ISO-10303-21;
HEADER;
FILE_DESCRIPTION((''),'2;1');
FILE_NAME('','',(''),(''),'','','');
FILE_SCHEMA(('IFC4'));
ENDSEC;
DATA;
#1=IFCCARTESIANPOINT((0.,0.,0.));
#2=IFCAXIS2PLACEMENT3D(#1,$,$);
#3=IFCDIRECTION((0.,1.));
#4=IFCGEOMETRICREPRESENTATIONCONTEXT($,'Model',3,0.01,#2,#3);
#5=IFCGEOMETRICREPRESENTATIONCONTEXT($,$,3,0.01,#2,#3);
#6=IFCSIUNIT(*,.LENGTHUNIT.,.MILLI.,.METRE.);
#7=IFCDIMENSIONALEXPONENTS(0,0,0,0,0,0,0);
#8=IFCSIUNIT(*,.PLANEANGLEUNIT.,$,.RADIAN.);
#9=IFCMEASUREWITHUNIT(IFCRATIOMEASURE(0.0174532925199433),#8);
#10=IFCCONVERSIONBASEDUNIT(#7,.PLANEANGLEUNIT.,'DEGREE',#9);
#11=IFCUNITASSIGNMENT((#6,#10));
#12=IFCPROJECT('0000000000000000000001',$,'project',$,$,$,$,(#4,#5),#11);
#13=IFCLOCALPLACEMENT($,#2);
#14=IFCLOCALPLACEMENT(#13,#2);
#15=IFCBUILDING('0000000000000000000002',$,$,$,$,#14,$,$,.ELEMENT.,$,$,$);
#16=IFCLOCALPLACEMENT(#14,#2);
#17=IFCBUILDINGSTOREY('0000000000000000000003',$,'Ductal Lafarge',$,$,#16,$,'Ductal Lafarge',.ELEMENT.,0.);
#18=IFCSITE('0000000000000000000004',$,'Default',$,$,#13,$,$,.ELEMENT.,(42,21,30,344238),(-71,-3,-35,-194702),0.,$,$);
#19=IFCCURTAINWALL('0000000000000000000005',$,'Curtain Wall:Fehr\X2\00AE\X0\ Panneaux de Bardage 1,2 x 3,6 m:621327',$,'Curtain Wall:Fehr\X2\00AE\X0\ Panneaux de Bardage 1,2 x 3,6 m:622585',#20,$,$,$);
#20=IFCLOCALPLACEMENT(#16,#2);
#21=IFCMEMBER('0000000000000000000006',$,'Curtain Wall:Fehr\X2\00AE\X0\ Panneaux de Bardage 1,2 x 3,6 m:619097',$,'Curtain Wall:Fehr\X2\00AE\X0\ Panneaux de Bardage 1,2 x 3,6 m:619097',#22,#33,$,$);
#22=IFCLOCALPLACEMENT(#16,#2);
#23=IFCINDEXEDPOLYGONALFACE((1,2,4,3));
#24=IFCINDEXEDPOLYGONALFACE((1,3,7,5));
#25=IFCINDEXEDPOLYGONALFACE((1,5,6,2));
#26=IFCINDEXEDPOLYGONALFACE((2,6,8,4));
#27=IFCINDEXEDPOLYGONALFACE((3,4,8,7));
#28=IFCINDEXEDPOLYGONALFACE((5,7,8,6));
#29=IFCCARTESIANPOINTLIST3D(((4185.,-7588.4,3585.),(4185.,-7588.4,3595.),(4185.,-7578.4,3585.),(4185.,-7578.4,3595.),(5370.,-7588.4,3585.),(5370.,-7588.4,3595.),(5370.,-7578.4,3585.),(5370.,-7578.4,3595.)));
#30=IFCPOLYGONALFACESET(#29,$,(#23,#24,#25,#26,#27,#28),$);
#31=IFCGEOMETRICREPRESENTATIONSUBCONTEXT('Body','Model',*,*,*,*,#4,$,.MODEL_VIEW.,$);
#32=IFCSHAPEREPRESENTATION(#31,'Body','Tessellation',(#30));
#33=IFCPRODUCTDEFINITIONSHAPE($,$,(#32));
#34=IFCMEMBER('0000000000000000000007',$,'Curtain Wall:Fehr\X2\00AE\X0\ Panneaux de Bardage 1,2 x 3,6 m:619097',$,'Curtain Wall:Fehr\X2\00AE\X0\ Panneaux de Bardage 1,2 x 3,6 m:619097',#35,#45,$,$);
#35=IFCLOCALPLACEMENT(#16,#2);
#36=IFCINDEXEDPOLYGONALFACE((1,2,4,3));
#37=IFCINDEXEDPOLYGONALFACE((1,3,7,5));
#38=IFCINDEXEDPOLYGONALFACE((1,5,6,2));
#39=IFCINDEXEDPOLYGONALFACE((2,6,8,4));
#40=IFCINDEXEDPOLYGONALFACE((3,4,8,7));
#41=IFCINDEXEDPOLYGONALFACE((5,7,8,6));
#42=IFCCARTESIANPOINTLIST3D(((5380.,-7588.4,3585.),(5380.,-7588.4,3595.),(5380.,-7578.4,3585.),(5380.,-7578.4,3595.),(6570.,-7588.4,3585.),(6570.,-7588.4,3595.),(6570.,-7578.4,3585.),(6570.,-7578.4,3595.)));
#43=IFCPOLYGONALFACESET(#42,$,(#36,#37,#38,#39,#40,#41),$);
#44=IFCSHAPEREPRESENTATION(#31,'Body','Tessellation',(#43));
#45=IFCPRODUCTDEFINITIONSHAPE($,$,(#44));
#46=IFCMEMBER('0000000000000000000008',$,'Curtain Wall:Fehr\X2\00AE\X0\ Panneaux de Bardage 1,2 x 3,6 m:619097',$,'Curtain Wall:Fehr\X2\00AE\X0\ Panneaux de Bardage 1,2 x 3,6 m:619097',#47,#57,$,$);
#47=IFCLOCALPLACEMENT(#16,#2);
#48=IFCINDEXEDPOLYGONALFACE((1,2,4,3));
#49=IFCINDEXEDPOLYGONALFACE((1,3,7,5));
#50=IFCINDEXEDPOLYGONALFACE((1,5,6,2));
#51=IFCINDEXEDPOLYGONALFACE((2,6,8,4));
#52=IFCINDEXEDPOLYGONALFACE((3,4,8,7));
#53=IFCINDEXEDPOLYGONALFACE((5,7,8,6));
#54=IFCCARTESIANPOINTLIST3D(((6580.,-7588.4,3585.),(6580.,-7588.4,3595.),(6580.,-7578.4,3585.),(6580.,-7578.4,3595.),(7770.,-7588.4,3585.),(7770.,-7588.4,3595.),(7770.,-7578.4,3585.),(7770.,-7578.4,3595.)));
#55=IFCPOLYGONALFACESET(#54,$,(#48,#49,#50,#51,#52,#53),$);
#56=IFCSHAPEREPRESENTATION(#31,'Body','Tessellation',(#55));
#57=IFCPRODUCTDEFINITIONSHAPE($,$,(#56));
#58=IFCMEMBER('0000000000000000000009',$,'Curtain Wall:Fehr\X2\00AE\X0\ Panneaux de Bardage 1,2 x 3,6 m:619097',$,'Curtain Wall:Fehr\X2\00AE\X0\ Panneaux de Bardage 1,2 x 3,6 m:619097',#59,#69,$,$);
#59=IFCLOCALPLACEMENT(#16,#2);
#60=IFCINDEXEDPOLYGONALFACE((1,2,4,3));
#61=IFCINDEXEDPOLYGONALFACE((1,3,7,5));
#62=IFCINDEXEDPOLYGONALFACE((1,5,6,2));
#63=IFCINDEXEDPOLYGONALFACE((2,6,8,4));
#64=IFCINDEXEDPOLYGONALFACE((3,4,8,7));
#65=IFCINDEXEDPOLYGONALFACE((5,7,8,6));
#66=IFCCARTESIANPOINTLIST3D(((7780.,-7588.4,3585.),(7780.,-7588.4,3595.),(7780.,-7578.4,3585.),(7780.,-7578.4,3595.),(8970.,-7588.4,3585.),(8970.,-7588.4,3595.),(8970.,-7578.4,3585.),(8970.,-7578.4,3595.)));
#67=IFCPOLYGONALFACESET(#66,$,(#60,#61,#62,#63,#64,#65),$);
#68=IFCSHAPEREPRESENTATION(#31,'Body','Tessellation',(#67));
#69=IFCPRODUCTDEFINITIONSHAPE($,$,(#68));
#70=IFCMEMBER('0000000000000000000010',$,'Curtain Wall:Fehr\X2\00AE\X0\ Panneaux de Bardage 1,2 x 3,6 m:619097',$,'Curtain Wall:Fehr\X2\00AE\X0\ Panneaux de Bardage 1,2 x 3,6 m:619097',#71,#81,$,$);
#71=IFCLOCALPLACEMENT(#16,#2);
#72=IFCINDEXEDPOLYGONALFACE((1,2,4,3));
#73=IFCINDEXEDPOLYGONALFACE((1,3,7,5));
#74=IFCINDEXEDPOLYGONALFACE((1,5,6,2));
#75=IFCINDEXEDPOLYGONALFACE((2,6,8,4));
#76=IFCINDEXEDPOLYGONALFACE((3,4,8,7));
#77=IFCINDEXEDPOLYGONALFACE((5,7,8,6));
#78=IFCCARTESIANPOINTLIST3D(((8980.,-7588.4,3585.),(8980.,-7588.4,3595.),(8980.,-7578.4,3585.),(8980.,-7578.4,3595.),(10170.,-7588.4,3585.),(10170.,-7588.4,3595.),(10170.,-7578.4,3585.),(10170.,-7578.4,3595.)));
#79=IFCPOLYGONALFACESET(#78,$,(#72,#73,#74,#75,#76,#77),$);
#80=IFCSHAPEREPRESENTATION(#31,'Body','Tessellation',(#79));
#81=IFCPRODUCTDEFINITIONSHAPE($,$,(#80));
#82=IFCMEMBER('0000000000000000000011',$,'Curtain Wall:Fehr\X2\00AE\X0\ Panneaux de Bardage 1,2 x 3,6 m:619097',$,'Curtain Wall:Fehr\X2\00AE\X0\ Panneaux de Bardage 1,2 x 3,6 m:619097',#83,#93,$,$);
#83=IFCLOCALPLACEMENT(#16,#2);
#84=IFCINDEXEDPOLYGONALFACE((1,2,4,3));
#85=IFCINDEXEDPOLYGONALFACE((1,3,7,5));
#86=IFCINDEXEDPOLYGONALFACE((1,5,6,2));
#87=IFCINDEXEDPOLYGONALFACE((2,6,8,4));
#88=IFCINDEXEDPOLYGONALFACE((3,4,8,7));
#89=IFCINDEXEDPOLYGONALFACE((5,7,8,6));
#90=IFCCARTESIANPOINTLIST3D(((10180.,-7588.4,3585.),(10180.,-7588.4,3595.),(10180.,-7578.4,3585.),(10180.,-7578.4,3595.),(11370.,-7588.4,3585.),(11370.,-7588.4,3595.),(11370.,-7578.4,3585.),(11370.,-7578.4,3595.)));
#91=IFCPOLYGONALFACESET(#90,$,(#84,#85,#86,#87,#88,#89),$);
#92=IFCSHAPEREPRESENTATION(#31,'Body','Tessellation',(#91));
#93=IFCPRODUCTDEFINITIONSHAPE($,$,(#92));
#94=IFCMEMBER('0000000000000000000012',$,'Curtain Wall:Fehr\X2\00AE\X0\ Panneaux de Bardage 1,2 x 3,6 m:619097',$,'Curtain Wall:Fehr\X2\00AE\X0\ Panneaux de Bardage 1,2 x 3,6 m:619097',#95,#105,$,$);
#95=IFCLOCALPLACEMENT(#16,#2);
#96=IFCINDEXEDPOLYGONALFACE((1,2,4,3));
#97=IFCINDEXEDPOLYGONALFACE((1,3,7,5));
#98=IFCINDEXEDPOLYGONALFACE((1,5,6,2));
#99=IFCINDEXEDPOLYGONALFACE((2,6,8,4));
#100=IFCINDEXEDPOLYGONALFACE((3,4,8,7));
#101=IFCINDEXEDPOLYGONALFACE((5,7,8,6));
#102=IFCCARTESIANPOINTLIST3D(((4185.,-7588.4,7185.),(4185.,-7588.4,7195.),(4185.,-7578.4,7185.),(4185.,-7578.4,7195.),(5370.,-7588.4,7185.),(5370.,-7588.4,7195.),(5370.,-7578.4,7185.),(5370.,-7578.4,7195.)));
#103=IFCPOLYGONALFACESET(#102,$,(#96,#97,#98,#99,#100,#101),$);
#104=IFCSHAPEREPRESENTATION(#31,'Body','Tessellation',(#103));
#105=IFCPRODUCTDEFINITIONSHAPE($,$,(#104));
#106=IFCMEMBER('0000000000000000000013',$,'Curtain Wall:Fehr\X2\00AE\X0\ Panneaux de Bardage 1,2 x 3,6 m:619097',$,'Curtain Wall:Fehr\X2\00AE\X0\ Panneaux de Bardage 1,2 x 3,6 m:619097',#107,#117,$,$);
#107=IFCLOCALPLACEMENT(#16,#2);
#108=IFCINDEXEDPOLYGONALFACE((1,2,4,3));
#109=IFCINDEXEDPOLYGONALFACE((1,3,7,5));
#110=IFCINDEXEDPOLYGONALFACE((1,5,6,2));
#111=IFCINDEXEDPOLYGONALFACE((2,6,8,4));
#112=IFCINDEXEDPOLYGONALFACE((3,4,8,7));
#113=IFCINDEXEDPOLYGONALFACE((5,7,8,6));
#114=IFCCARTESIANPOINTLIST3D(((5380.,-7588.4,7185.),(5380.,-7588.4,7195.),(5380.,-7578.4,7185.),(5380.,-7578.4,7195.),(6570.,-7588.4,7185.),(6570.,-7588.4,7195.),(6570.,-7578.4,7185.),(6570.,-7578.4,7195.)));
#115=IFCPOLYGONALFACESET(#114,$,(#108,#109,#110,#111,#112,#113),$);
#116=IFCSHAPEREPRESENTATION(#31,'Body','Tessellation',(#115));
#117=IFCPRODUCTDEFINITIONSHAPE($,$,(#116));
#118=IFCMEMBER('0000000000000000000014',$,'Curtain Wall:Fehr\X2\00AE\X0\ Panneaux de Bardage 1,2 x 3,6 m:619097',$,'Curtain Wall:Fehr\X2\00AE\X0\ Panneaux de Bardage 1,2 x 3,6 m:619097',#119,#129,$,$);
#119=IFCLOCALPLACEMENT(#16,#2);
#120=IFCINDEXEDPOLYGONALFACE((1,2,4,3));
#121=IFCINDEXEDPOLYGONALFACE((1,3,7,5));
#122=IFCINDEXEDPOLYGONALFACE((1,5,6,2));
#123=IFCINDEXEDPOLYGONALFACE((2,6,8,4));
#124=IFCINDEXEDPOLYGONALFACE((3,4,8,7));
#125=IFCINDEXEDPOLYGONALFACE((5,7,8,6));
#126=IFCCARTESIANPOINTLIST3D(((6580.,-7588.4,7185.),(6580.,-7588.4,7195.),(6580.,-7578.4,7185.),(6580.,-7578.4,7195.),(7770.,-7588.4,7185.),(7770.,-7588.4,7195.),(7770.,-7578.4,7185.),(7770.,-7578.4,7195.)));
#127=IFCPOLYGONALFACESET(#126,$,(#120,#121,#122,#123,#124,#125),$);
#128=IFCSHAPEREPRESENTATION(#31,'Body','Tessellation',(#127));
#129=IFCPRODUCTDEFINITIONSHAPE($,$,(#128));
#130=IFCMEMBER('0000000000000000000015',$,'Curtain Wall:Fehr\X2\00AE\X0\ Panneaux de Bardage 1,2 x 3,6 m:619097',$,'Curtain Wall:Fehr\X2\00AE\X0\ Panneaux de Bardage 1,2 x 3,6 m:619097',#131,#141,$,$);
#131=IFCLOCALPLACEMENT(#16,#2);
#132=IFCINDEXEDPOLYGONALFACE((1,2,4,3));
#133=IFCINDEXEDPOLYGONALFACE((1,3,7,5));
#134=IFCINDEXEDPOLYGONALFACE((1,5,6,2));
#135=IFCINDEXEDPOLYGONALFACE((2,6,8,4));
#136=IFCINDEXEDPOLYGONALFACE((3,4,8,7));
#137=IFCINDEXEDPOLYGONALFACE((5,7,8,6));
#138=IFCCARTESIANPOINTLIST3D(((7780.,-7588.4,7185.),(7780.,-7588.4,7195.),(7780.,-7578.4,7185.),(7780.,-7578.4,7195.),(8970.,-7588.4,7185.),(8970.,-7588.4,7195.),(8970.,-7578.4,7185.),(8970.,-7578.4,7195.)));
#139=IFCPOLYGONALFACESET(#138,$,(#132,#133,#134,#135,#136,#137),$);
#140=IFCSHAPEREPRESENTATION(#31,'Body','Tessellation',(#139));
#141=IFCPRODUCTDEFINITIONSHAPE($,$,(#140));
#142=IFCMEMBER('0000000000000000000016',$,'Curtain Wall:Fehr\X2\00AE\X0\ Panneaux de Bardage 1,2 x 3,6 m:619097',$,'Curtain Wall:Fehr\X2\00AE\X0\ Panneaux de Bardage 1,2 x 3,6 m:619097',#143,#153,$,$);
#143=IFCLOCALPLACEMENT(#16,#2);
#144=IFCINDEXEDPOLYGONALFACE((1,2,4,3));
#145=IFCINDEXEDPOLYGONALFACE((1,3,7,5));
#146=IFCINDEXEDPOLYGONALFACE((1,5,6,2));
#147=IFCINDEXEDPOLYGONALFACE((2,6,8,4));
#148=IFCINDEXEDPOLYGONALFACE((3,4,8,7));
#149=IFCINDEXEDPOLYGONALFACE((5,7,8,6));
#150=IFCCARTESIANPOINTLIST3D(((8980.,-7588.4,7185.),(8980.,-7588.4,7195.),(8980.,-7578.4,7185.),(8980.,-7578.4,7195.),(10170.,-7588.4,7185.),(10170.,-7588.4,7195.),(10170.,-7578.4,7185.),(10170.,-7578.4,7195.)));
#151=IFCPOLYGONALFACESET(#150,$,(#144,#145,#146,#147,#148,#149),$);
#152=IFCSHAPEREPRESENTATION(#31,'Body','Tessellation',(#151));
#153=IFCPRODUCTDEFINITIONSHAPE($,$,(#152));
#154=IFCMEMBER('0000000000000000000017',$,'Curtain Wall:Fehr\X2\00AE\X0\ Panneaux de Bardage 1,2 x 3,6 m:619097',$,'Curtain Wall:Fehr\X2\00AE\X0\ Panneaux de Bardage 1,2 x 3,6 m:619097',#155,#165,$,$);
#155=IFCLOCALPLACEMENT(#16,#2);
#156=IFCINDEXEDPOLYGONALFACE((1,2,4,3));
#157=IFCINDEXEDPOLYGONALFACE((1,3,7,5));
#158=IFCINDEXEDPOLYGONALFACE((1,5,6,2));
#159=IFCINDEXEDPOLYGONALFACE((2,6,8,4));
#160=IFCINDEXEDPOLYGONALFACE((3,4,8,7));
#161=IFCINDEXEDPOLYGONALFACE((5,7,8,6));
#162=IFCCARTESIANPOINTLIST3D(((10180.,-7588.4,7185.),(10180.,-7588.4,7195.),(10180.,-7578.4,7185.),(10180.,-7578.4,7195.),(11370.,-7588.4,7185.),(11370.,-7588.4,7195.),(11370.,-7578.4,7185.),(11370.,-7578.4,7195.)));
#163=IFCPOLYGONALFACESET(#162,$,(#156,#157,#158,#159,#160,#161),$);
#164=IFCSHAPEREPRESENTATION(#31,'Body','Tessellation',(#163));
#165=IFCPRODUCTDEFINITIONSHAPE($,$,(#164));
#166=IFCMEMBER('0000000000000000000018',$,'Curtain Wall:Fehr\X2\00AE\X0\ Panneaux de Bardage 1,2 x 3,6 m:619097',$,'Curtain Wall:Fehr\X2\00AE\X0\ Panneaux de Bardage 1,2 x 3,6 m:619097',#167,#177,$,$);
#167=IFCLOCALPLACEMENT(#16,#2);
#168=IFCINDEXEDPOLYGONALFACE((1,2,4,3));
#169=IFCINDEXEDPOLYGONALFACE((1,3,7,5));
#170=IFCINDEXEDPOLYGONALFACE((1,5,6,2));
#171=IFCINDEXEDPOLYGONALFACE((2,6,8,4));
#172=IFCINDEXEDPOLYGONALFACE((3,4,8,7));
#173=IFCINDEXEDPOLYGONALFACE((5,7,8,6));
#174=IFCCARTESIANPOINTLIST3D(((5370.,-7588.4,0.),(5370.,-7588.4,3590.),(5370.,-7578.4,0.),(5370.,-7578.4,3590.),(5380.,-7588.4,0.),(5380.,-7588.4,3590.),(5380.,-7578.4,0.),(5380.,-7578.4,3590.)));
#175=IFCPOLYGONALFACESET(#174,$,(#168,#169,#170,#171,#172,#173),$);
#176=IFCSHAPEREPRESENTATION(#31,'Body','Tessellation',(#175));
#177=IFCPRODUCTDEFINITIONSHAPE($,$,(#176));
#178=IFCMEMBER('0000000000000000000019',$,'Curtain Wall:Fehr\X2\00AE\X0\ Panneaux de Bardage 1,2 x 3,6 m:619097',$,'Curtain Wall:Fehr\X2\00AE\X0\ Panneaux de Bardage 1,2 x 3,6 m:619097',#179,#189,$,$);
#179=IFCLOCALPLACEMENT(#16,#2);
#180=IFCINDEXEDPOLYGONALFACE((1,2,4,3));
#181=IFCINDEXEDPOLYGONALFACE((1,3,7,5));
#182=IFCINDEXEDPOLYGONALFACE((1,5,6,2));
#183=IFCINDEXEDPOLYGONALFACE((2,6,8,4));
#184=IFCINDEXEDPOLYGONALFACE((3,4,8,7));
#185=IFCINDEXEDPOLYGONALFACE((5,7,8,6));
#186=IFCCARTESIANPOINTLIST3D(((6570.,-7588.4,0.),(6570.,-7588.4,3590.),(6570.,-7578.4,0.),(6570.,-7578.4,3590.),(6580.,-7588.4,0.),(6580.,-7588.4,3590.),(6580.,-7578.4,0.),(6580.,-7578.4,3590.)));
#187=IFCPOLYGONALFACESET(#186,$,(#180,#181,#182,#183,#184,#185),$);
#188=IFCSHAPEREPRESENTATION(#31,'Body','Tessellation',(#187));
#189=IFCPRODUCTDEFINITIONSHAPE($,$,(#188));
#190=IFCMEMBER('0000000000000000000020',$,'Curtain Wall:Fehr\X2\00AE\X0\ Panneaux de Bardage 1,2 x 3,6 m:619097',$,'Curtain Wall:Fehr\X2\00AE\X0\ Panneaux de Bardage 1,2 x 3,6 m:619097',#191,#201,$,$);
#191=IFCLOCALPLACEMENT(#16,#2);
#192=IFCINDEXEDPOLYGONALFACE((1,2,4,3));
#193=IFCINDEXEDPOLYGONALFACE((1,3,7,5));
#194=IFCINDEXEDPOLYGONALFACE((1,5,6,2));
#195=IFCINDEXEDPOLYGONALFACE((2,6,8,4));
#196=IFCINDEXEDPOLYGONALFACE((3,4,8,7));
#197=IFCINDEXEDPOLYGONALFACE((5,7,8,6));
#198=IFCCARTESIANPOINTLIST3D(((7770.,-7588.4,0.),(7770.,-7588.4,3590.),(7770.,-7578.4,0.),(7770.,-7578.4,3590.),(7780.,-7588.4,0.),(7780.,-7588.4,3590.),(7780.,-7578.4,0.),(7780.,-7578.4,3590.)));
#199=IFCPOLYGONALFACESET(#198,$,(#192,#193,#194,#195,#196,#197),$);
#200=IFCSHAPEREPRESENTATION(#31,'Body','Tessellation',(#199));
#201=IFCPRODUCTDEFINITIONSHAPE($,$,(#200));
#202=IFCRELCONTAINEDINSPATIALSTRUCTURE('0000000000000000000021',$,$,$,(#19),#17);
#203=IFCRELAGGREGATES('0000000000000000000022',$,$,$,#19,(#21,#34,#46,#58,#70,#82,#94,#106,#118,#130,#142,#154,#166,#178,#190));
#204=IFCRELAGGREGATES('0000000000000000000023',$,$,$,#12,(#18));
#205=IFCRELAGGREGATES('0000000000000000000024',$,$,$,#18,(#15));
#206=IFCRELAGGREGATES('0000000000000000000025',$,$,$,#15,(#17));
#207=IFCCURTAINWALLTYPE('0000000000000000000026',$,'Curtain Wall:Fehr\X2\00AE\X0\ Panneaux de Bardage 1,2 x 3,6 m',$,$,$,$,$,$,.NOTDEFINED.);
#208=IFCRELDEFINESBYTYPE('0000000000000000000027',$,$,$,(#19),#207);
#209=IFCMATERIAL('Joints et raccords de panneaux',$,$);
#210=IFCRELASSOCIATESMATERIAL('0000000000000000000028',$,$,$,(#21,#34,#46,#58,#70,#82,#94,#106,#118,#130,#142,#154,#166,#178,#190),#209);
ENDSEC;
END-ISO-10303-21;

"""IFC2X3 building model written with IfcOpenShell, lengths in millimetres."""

from ifc_helpers import new_model, entity, si_unit, converted_unit, direction, frame, frame_2d, origin, origin_2d_with_axis, place, context, subcontext, project, spatial, rectangle, extrude, material, type_object, element, aggregate, save


model = new_model("IFC2X3")

# Units and contexts
model_context = context("Model", 3, precision=0.01, world=origin(), true_north=direction((0.0, 1.0)))
context_of_model = context(None, 3, precision=0.01, world=origin(), true_north=direction((0.0, 1.0)))
body_context = subcontext(model_context, "Body", "Model", "MODEL_VIEW")
ifc_project = project(units=[si_unit("LENGTHUNIT", "METRE", prefix="MILLI"), converted_unit("PLANEANGLEUNIT", "DEGREE", entity("IfcRatioMeasure", 0.0174532925199433), si_unit("PLANEANGLEUNIT", "RADIAN"), dimensions=[0, 0, 0, 0, 0, 0, 0])], contexts=[model_context, context_of_model])

# Site, building, storey
site_placement = place(None, origin())
site = spatial("IfcSite", under=ifc_project, at=site_placement, Name="Default", CompositionType="ELEMENT", RefLatitude=(42, 21, 30, 344238), RefLongitude=(-71, -3, -35, -194702), RefElevation=0.0)
building_placement = place(site_placement, origin())
building = spatial("IfcBuilding", under=site, at=building_placement, CompositionType="ELEMENT")
storey_placement = place(building_placement, origin())
storey = spatial("IfcBuildingStorey", under=building, at=storey_placement, Name="Ductal Lafarge", LongName="Ductal Lafarge", CompositionType="ELEMENT", Elevation=0.0)

# Curtain wall, members
curtain_wall_type = type_object("IfcCurtainWallType", Name="Curtain Wall:Fehr® Panneaux de Bardage 1,2 x 3,6 m", PredefinedType="NOTDEFINED")
curtain_wall_placement = place(storey_placement, origin())
curtain_wall = element("IfcCurtainWall", 1, at=curtain_wall_placement, inside=storey, type_object=curtain_wall_type, Name="Curtain Wall:Fehr® Panneaux de Bardage 1,2 x 3,6 m:621327", ObjectType="Curtain Wall:Fehr® Panneaux de Bardage 1,2 x 3,6 m:622585")
ifc_material = material(Name="Joints et raccords de panneaux")
member_1_placement = place(curtain_wall_placement, frame((4185.0, -7588.4, 3585.0)))
member_1 = element("IfcMember", 2, at=member_1_placement, material=ifc_material, Name="Curtain Wall:Fehr® Panneaux de Bardage 1,2 x 3,6 m:619097", ObjectType="Curtain Wall:Fehr® Panneaux de Bardage 1,2 x 3,6 m:619097", context=body_context, shape_type="SweptSolid", body=[
    extrude(rectangle(XDim=1185.0, YDim=10.0, at=origin_2d_with_axis()), frame((592.5, 5.0, 0.0), z_axis=(0.0, 0.0, 1.0), x_axis=(-1.0, 0.0, 0.0)), (0.0, 0.0, 1.0), 10.0),
])
member_2_placement = place(curtain_wall_placement, frame((5380.0, -7588.4, 3585.0)))
member_2 = element("IfcMember", 3, at=member_2_placement, material=ifc_material, Name="Curtain Wall:Fehr® Panneaux de Bardage 1,2 x 3,6 m:619097", ObjectType="Curtain Wall:Fehr® Panneaux de Bardage 1,2 x 3,6 m:619097", context=body_context, shape_type="SweptSolid", body=[
    extrude(rectangle(XDim=1190.0, YDim=10.0, at=frame_2d((0.0, 0.0), x_axis=(1.0, 0.0))), frame((595.0, 5.0, 0.0), z_axis=(0.0, 0.0, 1.0), x_axis=(-1.0, 0.0, 0.0)), (0.0, 0.0, 1.0), 10.0),
])
member_3_placement = place(curtain_wall_placement, frame((6580.0, -7588.4, 3585.0)))
member_3 = element("IfcMember", 4, at=member_3_placement, material=ifc_material, Name="Curtain Wall:Fehr® Panneaux de Bardage 1,2 x 3,6 m:619097", ObjectType="Curtain Wall:Fehr® Panneaux de Bardage 1,2 x 3,6 m:619097", context=body_context, shape_type="SweptSolid", body=[
    extrude(rectangle(XDim=1190.0, YDim=10.0, at=frame_2d((0.0, 0.0), x_axis=(1.0, 0.0))), frame((595.0, 5.0, 0.0), z_axis=(0.0, 0.0, 1.0), x_axis=(-1.0, 0.0, 0.0)), (0.0, 0.0, 1.0), 10.0),
])
member_4_placement = place(curtain_wall_placement, frame((7780.0, -7588.4, 3585.0)))
member_4 = element("IfcMember", 5, at=member_4_placement, material=ifc_material, Name="Curtain Wall:Fehr® Panneaux de Bardage 1,2 x 3,6 m:619097", ObjectType="Curtain Wall:Fehr® Panneaux de Bardage 1,2 x 3,6 m:619097", context=body_context, shape_type="SweptSolid", body=[
    extrude(rectangle(XDim=1190.0, YDim=10.0, at=frame_2d((0.0, 0.0), x_axis=(1.0, 0.0))), frame((595.0, 5.0, 0.0), z_axis=(0.0, 0.0, 1.0), x_axis=(-1.0, 0.0, 0.0)), (0.0, 0.0, 1.0), 10.0),
])
member_5_placement = place(curtain_wall_placement, frame((8980.0, -7588.4, 3585.0)))
member_5 = element("IfcMember", 6, at=member_5_placement, material=ifc_material, Name="Curtain Wall:Fehr® Panneaux de Bardage 1,2 x 3,6 m:619097", ObjectType="Curtain Wall:Fehr® Panneaux de Bardage 1,2 x 3,6 m:619097", context=body_context, shape_type="SweptSolid", body=[
    extrude(rectangle(XDim=1190.0, YDim=10.0, at=origin_2d_with_axis()), frame((595.0, 5.0, 0.0), z_axis=(0.0, 0.0, 1.0), x_axis=(-1.0, 0.0, 0.0)), (0.0, 0.0, 1.0), 10.0),
])
member_6_placement = place(curtain_wall_placement, frame((10180.0, -7588.4, 3585.0)))
member_6 = element("IfcMember", 7, at=member_6_placement, material=ifc_material, Name="Curtain Wall:Fehr® Panneaux de Bardage 1,2 x 3,6 m:619097", ObjectType="Curtain Wall:Fehr® Panneaux de Bardage 1,2 x 3,6 m:619097", context=body_context, shape_type="SweptSolid", body=[
    extrude(rectangle(XDim=1190.0, YDim=10.0, at=frame_2d((0.0, 0.0), x_axis=(1.0, 0.0))), frame((595.0, 5.0, 0.0), z_axis=(0.0, 0.0, 1.0), x_axis=(-1.0, 0.0, 0.0)), (0.0, 0.0, 1.0), 10.0),
])
member_7_placement = place(curtain_wall_placement, frame((4185.0, -7588.4, 7185.0)))
member_7 = element("IfcMember", 8, at=member_7_placement, material=ifc_material, Name="Curtain Wall:Fehr® Panneaux de Bardage 1,2 x 3,6 m:619097", ObjectType="Curtain Wall:Fehr® Panneaux de Bardage 1,2 x 3,6 m:619097", context=body_context, shape_type="SweptSolid", body=[
    extrude(rectangle(XDim=1185.0, YDim=10.0, at=origin_2d_with_axis()), frame((592.5, 5.0, 0.0), z_axis=(0.0, 0.0, 1.0), x_axis=(-1.0, 0.0, 0.0)), (0.0, 0.0, 1.0), 10.0),
])
member_8_placement = place(curtain_wall_placement, frame((5380.0, -7588.4, 7185.0)))
member_8 = element("IfcMember", 9, at=member_8_placement, material=ifc_material, Name="Curtain Wall:Fehr® Panneaux de Bardage 1,2 x 3,6 m:619097", ObjectType="Curtain Wall:Fehr® Panneaux de Bardage 1,2 x 3,6 m:619097", context=body_context, shape_type="SweptSolid", body=[
    extrude(rectangle(XDim=1190.0, YDim=10.0, at=frame_2d((0.0, 0.0), x_axis=(1.0, 0.0))), frame((595.0, 5.0, 0.0), z_axis=(0.0, 0.0, 1.0), x_axis=(-1.0, 0.0, 0.0)), (0.0, 0.0, 1.0), 10.0),
])
member_9_placement = place(curtain_wall_placement, frame((6580.0, -7588.4, 7185.0)))
member_9 = element("IfcMember", 10, at=member_9_placement, material=ifc_material, Name="Curtain Wall:Fehr® Panneaux de Bardage 1,2 x 3,6 m:619097", ObjectType="Curtain Wall:Fehr® Panneaux de Bardage 1,2 x 3,6 m:619097", context=body_context, shape_type="SweptSolid", body=[
    extrude(rectangle(XDim=1190.0, YDim=10.0, at=frame_2d((0.0, 0.0), x_axis=(1.0, 0.0))), frame((595.0, 5.0, 0.0), z_axis=(0.0, 0.0, 1.0), x_axis=(-1.0, 0.0, 0.0)), (0.0, 0.0, 1.0), 10.0),
])
member_10_placement = place(curtain_wall_placement, frame((7780.0, -7588.4, 7185.0)))
member_10 = element("IfcMember", 11, at=member_10_placement, material=ifc_material, Name="Curtain Wall:Fehr® Panneaux de Bardage 1,2 x 3,6 m:619097", ObjectType="Curtain Wall:Fehr® Panneaux de Bardage 1,2 x 3,6 m:619097", context=body_context, shape_type="SweptSolid", body=[
    extrude(rectangle(XDim=1190.0, YDim=10.0, at=frame_2d((0.0, 0.0), x_axis=(1.0, 0.0))), frame((595.0, 5.0, 0.0), z_axis=(0.0, 0.0, 1.0), x_axis=(-1.0, 0.0, 0.0)), (0.0, 0.0, 1.0), 10.0),
])
member_11_placement = place(curtain_wall_placement, frame((8980.0, -7588.4, 7185.0)))
member_11 = element("IfcMember", 12, at=member_11_placement, material=ifc_material, Name="Curtain Wall:Fehr® Panneaux de Bardage 1,2 x 3,6 m:619097", ObjectType="Curtain Wall:Fehr® Panneaux de Bardage 1,2 x 3,6 m:619097", context=body_context, shape_type="SweptSolid", body=[
    extrude(rectangle(XDim=1190.0, YDim=10.0, at=origin_2d_with_axis()), frame((595.0, 5.0, 0.0), z_axis=(0.0, 0.0, 1.0), x_axis=(-1.0, 0.0, 0.0)), (0.0, 0.0, 1.0), 10.0),
])
member_12_placement = place(curtain_wall_placement, frame((10180.0, -7588.4, 7185.0)))
member_12 = element("IfcMember", 13, at=member_12_placement, material=ifc_material, Name="Curtain Wall:Fehr® Panneaux de Bardage 1,2 x 3,6 m:619097", ObjectType="Curtain Wall:Fehr® Panneaux de Bardage 1,2 x 3,6 m:619097", context=body_context, shape_type="SweptSolid", body=[
    extrude(rectangle(XDim=1190.0, YDim=10.0, at=frame_2d((0.0, 0.0), x_axis=(1.0, 0.0))), frame((595.0, 5.0, 0.0), z_axis=(0.0, 0.0, 1.0), x_axis=(-1.0, 0.0, 0.0)), (0.0, 0.0, 1.0), 10.0),
])
member_13_placement = place(curtain_wall_placement, frame((5370.0, -7588.4, 0.0)))
member_13 = element("IfcMember", 14, at=member_13_placement, material=ifc_material, Name="Curtain Wall:Fehr® Panneaux de Bardage 1,2 x 3,6 m:619097", ObjectType="Curtain Wall:Fehr® Panneaux de Bardage 1,2 x 3,6 m:619097", context=body_context, shape_type="SweptSolid", body=[
    extrude(rectangle(XDim=10.0, YDim=10.0, at=frame_2d((0.0, 0.0), x_axis=(1.0, 0.0))), frame((5.0, 5.0, 0.0), z_axis=(0.0, 0.0, 1.0), x_axis=(0.0, 1.0, 0.0)), (0.0, 0.0, 1.0), 3590.0),
])
member_14_placement = place(curtain_wall_placement, frame((6570.0, -7588.4, 0.0)))
member_14 = element("IfcMember", 15, at=member_14_placement, material=ifc_material, Name="Curtain Wall:Fehr® Panneaux de Bardage 1,2 x 3,6 m:619097", ObjectType="Curtain Wall:Fehr® Panneaux de Bardage 1,2 x 3,6 m:619097", context=body_context, shape_type="SweptSolid", body=[
    extrude(rectangle(XDim=10.0, YDim=10.0, at=frame_2d((0.0, 0.0), x_axis=(1.0, 0.0))), frame((5.0, 5.0, 0.0), z_axis=(0.0, 0.0, 1.0), x_axis=(0.0, 1.0, 0.0)), (0.0, 0.0, 1.0), 3590.0),
])
member_15_placement = place(curtain_wall_placement, frame((7770.0, -7588.4, 0.0)))
member_15 = element("IfcMember", 16, at=member_15_placement, material=ifc_material, Name="Curtain Wall:Fehr® Panneaux de Bardage 1,2 x 3,6 m:619097", ObjectType="Curtain Wall:Fehr® Panneaux de Bardage 1,2 x 3,6 m:619097", context=body_context, shape_type="SweptSolid", body=[
    extrude(rectangle(XDim=10.0, YDim=10.0, at=frame_2d((0.0, 0.0), x_axis=(1.0, 0.0))), frame((5.0, 5.0, 0.0), z_axis=(0.0, 0.0, 1.0), x_axis=(0.0, 1.0, 0.0)), (0.0, 0.0, 1.0), 3590.0),
])
aggregate(curtain_wall, [member_1, member_2, member_3, member_4, member_5, member_6, member_7, member_8, member_9, member_10, member_11, member_12, member_13, member_14, member_15])

save(model, "model.ifc")
